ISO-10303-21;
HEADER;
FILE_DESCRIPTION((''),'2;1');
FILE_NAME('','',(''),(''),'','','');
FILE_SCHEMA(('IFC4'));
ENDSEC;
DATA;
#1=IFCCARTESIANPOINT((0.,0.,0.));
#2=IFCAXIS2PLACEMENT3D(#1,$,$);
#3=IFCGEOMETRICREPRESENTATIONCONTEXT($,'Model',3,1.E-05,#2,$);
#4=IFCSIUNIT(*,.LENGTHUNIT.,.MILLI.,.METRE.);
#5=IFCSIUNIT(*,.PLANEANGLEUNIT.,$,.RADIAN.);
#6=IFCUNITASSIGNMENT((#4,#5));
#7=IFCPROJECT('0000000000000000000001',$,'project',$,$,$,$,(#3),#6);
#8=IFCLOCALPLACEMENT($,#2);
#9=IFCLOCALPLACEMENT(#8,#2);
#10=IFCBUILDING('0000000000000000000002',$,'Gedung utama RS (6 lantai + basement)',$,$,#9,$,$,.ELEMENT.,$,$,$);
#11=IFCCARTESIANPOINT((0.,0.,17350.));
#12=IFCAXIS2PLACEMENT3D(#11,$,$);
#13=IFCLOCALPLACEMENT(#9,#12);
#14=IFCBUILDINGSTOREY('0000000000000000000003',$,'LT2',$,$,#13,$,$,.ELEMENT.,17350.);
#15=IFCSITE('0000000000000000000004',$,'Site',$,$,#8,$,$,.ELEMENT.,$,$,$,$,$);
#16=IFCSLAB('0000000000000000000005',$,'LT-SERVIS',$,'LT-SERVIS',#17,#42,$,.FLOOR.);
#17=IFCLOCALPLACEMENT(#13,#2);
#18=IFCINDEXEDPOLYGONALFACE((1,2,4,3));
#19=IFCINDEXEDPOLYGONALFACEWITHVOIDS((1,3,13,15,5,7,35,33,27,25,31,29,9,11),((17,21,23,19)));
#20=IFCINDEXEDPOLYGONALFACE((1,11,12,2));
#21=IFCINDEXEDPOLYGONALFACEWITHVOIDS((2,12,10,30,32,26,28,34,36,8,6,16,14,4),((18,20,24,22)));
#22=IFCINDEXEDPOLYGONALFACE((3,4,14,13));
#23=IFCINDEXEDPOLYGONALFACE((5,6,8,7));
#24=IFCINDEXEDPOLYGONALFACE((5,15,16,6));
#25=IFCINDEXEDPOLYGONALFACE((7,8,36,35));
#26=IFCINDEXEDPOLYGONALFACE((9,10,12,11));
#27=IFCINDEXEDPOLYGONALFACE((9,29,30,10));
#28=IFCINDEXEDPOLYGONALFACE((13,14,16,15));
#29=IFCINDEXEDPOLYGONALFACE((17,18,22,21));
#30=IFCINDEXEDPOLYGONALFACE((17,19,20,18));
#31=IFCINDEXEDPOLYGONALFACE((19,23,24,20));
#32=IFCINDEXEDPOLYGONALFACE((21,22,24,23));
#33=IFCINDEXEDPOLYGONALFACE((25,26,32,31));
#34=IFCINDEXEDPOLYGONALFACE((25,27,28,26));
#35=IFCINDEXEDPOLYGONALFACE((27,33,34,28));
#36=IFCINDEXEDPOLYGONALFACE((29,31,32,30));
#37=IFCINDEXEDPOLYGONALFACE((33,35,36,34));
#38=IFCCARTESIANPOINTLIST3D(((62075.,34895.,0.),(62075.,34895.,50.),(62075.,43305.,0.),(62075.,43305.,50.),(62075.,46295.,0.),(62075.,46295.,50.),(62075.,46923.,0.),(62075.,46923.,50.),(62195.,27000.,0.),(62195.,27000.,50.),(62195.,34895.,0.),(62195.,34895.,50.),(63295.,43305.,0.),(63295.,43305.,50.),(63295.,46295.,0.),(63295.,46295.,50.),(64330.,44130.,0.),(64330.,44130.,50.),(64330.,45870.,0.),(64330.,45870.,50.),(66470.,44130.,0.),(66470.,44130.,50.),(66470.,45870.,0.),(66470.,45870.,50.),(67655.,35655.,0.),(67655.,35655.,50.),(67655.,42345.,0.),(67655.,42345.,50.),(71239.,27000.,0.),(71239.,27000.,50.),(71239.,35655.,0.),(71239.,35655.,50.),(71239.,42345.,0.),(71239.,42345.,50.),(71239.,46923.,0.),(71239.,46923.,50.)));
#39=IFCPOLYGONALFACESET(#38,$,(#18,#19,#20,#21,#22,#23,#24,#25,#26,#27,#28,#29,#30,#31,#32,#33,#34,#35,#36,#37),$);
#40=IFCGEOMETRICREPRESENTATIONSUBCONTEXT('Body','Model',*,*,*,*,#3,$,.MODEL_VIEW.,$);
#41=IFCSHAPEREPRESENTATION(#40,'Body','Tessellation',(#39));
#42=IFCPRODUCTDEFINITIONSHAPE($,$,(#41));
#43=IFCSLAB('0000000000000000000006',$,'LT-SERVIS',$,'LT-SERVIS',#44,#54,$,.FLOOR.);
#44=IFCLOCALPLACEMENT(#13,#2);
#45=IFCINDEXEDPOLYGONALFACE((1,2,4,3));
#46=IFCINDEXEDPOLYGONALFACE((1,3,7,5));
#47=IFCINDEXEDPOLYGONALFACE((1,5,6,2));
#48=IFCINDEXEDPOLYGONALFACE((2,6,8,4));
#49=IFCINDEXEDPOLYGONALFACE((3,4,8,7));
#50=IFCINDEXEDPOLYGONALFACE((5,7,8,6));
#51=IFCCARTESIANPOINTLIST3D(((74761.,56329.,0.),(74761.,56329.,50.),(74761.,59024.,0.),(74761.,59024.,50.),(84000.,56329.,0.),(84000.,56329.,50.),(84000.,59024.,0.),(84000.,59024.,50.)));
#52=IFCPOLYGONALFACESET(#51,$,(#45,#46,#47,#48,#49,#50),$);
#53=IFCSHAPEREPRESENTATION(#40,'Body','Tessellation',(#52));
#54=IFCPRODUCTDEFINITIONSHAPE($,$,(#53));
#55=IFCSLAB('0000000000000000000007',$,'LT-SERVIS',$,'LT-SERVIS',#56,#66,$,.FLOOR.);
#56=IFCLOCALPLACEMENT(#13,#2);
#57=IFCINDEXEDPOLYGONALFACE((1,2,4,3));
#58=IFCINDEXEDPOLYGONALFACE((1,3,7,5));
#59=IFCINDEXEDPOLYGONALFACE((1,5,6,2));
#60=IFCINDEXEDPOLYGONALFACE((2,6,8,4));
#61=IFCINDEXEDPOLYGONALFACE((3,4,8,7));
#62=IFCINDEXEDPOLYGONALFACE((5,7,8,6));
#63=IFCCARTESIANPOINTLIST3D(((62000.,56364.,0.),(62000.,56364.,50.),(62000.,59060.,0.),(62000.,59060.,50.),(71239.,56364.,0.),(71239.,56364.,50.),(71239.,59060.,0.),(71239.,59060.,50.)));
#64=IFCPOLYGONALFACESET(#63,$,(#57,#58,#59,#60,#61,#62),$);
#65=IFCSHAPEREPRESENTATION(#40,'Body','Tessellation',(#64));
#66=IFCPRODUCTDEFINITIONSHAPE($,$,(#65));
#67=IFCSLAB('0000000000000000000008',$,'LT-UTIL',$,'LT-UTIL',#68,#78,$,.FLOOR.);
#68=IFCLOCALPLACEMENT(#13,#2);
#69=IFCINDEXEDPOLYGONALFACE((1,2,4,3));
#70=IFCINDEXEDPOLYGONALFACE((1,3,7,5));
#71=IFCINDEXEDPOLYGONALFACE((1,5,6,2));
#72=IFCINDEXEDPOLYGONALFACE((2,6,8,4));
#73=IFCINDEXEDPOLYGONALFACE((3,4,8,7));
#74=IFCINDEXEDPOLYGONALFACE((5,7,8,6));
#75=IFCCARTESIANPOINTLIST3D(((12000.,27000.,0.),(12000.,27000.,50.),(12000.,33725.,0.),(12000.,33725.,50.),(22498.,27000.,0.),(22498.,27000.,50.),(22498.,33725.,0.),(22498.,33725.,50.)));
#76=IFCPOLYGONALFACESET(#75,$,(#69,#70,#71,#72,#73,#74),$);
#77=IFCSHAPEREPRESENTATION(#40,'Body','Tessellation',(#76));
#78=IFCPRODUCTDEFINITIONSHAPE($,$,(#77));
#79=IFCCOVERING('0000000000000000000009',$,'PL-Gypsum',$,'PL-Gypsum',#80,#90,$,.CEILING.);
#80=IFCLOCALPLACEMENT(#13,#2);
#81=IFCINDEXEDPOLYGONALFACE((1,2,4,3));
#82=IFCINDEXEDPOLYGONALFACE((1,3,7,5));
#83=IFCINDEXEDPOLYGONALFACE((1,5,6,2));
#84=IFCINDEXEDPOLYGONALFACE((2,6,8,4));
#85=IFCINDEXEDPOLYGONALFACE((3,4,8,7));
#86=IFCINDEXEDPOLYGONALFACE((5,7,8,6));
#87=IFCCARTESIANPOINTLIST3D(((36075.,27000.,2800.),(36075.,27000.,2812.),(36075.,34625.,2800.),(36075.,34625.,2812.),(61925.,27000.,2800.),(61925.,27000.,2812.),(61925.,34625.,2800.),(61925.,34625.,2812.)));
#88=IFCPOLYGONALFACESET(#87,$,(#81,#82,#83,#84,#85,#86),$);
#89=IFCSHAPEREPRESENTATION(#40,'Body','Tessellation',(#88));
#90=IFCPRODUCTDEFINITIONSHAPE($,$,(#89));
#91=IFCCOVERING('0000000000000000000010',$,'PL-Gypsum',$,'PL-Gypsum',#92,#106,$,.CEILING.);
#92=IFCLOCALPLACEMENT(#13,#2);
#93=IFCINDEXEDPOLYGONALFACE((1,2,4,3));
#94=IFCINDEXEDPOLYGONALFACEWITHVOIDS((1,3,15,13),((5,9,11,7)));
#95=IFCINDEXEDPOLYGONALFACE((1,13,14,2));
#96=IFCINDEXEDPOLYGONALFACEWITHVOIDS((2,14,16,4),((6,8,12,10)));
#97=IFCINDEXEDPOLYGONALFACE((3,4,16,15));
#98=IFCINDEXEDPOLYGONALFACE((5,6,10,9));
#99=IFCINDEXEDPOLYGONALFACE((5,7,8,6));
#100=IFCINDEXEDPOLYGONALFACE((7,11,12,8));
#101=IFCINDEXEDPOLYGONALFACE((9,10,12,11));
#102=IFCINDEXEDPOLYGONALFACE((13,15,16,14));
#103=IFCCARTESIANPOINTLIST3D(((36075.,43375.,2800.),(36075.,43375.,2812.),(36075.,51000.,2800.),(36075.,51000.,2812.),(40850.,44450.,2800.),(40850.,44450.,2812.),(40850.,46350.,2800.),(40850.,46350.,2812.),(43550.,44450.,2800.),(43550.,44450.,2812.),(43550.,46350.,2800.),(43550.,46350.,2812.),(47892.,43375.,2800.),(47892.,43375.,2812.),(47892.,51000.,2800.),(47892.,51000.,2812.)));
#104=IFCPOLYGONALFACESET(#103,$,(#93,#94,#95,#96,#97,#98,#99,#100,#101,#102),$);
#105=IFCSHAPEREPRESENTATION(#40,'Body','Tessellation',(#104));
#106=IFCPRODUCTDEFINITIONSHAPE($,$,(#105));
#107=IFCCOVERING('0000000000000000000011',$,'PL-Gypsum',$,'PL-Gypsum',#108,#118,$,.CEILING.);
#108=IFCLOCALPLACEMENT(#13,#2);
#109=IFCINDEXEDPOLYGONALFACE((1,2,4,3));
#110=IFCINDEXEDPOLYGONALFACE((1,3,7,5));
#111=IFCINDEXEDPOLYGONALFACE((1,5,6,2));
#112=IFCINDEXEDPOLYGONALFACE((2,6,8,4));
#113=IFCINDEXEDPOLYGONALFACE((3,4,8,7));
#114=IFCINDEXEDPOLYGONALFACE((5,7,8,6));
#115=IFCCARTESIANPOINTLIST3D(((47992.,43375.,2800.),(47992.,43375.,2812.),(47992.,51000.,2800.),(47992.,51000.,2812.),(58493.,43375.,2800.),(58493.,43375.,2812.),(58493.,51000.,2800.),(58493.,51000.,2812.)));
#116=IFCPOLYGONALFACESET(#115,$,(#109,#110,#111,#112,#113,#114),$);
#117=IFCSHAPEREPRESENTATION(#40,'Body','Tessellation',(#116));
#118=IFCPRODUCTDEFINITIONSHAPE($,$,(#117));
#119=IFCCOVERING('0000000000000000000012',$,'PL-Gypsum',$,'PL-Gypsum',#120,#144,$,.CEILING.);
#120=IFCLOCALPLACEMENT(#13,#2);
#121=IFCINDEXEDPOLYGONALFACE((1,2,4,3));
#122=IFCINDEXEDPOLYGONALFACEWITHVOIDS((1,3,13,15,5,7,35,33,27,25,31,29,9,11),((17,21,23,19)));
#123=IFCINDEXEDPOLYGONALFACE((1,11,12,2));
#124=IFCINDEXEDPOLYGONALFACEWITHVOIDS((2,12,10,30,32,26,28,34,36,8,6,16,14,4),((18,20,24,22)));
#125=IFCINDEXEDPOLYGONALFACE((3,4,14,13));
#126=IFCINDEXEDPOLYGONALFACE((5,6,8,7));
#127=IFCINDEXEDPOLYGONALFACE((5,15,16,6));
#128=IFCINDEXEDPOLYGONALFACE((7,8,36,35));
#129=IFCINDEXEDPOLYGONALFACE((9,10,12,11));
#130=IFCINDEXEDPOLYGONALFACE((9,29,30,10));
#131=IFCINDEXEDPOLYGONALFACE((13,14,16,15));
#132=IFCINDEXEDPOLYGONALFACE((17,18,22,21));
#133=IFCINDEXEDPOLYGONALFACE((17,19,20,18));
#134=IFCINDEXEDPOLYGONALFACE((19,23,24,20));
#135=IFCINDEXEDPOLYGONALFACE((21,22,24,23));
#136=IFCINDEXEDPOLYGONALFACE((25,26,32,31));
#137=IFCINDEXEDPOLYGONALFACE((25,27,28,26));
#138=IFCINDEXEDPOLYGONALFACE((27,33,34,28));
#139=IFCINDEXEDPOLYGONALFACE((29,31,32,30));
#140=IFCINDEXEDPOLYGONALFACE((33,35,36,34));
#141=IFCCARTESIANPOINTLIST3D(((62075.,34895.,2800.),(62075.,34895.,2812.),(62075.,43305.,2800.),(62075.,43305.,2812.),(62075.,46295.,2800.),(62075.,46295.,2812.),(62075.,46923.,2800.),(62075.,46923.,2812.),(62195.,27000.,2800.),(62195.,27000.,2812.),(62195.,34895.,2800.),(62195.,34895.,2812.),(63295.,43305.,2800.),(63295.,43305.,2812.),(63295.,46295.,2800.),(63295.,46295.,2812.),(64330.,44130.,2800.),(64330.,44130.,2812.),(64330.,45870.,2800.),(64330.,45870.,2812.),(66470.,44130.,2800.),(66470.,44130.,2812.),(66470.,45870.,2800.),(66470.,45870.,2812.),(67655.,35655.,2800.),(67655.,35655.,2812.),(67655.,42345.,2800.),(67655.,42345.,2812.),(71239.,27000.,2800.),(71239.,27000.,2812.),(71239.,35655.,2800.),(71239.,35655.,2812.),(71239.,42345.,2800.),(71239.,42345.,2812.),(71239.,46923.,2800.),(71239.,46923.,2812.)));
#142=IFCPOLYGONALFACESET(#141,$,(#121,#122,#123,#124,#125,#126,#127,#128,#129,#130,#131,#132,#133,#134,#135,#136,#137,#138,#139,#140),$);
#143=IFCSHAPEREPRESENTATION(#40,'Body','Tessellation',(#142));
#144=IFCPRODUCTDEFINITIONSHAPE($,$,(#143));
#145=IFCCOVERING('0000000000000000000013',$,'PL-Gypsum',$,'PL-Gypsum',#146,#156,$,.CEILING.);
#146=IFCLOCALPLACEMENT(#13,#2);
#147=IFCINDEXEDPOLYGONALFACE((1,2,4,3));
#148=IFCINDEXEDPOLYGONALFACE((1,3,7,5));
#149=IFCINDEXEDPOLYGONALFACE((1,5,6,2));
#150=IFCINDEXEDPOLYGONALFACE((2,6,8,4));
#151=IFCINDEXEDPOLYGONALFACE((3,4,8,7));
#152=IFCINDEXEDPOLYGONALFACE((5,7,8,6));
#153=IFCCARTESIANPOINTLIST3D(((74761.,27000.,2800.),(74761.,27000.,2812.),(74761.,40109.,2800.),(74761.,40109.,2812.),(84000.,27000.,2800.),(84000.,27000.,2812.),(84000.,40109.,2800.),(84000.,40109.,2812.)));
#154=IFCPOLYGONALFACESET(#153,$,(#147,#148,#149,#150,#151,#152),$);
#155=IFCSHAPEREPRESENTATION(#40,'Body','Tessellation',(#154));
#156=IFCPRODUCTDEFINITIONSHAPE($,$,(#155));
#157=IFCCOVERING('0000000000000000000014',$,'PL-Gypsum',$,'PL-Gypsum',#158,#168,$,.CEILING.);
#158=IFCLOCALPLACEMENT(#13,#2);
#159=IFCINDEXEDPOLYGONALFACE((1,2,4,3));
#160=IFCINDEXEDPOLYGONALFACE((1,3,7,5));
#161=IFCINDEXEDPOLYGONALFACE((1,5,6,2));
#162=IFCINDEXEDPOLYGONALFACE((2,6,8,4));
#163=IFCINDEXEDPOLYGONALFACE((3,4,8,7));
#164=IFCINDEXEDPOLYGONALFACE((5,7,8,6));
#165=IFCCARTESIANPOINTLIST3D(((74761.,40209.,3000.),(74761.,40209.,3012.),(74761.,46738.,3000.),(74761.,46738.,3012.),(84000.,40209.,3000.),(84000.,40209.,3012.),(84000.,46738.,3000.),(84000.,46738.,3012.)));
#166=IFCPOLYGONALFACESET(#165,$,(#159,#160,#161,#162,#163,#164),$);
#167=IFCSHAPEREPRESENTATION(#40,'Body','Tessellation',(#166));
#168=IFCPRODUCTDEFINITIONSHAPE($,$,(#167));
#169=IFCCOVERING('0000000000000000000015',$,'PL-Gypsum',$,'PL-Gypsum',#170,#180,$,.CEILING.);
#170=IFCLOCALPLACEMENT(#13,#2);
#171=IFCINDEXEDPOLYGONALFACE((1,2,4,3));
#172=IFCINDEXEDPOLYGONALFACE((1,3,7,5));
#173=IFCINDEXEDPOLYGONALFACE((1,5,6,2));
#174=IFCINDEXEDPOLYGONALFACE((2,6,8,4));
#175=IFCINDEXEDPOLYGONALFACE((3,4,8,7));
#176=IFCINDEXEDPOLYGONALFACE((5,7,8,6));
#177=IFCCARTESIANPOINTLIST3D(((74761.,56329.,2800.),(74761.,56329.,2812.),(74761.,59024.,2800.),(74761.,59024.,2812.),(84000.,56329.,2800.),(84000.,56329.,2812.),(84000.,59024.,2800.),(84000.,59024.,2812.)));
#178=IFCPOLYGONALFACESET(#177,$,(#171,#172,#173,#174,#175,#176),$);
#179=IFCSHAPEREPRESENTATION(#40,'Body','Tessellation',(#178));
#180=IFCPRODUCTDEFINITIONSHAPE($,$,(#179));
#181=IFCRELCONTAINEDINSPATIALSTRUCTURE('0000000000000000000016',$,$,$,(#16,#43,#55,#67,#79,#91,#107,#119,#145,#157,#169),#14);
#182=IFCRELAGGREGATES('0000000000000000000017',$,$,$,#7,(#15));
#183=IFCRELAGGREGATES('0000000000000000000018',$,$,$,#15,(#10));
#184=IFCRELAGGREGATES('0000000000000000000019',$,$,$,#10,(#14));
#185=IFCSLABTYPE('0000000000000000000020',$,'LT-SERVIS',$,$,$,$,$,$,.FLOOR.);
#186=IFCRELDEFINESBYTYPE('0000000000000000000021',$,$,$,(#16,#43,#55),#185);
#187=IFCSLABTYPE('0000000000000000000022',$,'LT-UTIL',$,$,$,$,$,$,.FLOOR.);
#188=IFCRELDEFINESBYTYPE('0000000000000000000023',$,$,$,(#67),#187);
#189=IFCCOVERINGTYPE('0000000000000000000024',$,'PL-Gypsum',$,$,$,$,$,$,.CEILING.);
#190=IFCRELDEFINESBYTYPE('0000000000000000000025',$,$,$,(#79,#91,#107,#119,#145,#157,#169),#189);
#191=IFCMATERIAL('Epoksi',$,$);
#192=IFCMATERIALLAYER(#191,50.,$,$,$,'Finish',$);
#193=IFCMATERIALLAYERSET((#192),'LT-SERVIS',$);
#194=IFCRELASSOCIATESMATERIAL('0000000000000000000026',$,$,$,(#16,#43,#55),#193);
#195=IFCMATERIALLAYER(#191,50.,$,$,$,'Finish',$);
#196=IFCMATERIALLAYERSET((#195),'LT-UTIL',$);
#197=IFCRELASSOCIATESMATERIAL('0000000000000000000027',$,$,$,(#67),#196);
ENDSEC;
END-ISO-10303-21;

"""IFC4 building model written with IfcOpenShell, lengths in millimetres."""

from ifc_helpers import new_model, si_unit, frame, origin, place, context, subcontext, project, spatial, polyline, outline, extrude, material, layer, layer_set, layer_usage, type_object, element, save


model = new_model("IFC4")

# Units and contexts
model_context = context("Model", 3, precision=1e-05, world=origin())
body_context = subcontext(model_context, "Body", "Model", "MODEL_VIEW")
ifc_project = project(units=[si_unit("LENGTHUNIT", "METRE", prefix="MILLI"), si_unit("PLANEANGLEUNIT", "RADIAN")], contexts=[model_context])

# Site, building, storey
site_placement = place(None, origin())
site = spatial("IfcSite", under=ifc_project, at=site_placement, Name="Site", CompositionType="ELEMENT")
building_placement = place(site_placement, origin())
building = spatial("IfcBuilding", under=site, at=building_placement, Name="Gedung utama RS (6 lantai + basement)", CompositionType="ELEMENT")
storey_placement = place(building_placement, frame((0.0, 0.0, 17350.0)))
storey = spatial("IfcBuildingStorey", under=building, at=storey_placement, Name="LT2", CompositionType="ELEMENT", Elevation=17350.0)

# Slabs
ifc_material_1 = material(Name="Epoksi")
ifc_layer_1 = layer(ifc_material_1, 50.0, Category="Finish")
ifc_layer_set_1 = layer_set([ifc_layer_1], Name="LT-SERVIS")
ifc_layer_usage_1 = layer_usage(ifc_layer_set_1, "AXIS3", "NEGATIVE", 50.0)
slab_type_1 = type_object("IfcSlabType", Name="LT-SERVIS", PredefinedType="FLOOR")
slab_1_placement = place(storey_placement, origin())
element("IfcSlab", 1, at=slab_1_placement, inside=storey, type_object=slab_type_1, material=ifc_layer_usage_1, Name="LT-SERVIS", ObjectType="LT-SERVIS", PredefinedType="FLOOR", context=body_context, shape_type="SweptSolid", body=[
    extrude(outline(polyline([(62195.0, 27000.0), (71239.0, 27000.0), (71239.0, 35655.0), (67655.0, 35655.0), (67655.0, 42345.0), (71239.0, 42345.0), (71239.0, 46923.0), (62075.0, 46923.0), (62075.0, 46295.0), (63295.0, 46295.0), (63295.0, 43305.0), (62075.0, 43305.0), (62075.0, 34895.0), (62195.0, 34895.0), (62195.0, 27000.0)]), holes=[polyline([(64330.0, 44130.0), (64330.0, 45870.0), (66470.0, 45870.0), (66470.0, 44130.0), (64330.0, 44130.0)])]), origin(), (0.0, 0.0, 1.0), 50.0),
])
slab_2_placement = place(storey_placement, origin())
element("IfcSlab", 2, at=slab_2_placement, inside=storey, type_object=slab_type_1, material=ifc_layer_usage_1, Name="LT-SERVIS", ObjectType="LT-SERVIS", PredefinedType="FLOOR", context=body_context, shape_type="SweptSolid", body=[
    extrude(outline(polyline([(74761.0, 56329.0), (84000.0, 56329.0), (84000.0, 59024.0), (74761.0, 59024.0), (74761.0, 56329.0)])), origin(), (0.0, 0.0, 1.0), 50.0),
])
slab_3_placement = place(storey_placement, origin())
element("IfcSlab", 3, at=slab_3_placement, inside=storey, type_object=slab_type_1, material=ifc_layer_usage_1, Name="LT-SERVIS", ObjectType="LT-SERVIS", PredefinedType="FLOOR", context=body_context, shape_type="SweptSolid", body=[
    extrude(outline(polyline([(62000.0, 56364.0), (71239.0, 56364.0), (71239.0, 59060.0), (62000.0, 59060.0), (62000.0, 56364.0)])), origin(), (0.0, 0.0, 1.0), 50.0),
])
ifc_layer_2 = layer(ifc_material_1, 50.0, Category="Finish")
ifc_layer_set_2 = layer_set([ifc_layer_2], Name="LT-UTIL")
ifc_layer_usage_2 = layer_usage(ifc_layer_set_2, "AXIS3", "NEGATIVE", 50.0)
slab_type_2 = type_object("IfcSlabType", Name="LT-UTIL", PredefinedType="FLOOR")
slab_4_placement = place(storey_placement, origin())
element("IfcSlab", 4, at=slab_4_placement, inside=storey, type_object=slab_type_2, material=ifc_layer_usage_2, Name="LT-UTIL", ObjectType="LT-UTIL", PredefinedType="FLOOR", context=body_context, shape_type="SweptSolid", body=[
    extrude(outline(polyline([(12000.0, 27000.0), (22498.0, 27000.0), (22498.0, 33725.0), (12000.0, 33725.0), (12000.0, 27000.0)])), origin(), (0.0, 0.0, 1.0), 50.0),
])

# Coverings
covering_type = type_object("IfcCoveringType", Name="PL-Gypsum", PredefinedType="CEILING")
covering_1_placement = place(storey_placement, origin())
element("IfcCovering", 5, at=covering_1_placement, inside=storey, type_object=covering_type, Name="PL-Gypsum", ObjectType="PL-Gypsum", PredefinedType="CEILING", context=body_context, shape_type="SweptSolid", body=[
    extrude(outline(polyline([(36075.0, 27000.0), (61925.0, 27000.0), (61925.0, 34625.0), (36075.0, 34625.0), (36075.0, 27000.0)])), frame((0.0, 0.0, 2800.0)), (0.0, 0.0, 1.0), 12.0),
])
covering_2_placement = place(storey_placement, origin())
element("IfcCovering", 6, at=covering_2_placement, inside=storey, type_object=covering_type, Name="PL-Gypsum", ObjectType="PL-Gypsum", PredefinedType="CEILING", context=body_context, shape_type="SweptSolid", body=[
    extrude(outline(polyline([(36075.0, 43375.0), (47892.0, 43375.0), (47892.0, 51000.0), (36075.0, 51000.0), (36075.0, 43375.0)]), holes=[polyline([(40850.0, 44450.0), (40850.0, 46350.0), (43550.0, 46350.0), (43550.0, 44450.0), (40850.0, 44450.0)])]), frame((0.0, 0.0, 2800.0)), (0.0, 0.0, 1.0), 12.0),
])
covering_3_placement = place(storey_placement, origin())
element("IfcCovering", 7, at=covering_3_placement, inside=storey, type_object=covering_type, Name="PL-Gypsum", ObjectType="PL-Gypsum", PredefinedType="CEILING", context=body_context, shape_type="SweptSolid", body=[
    extrude(outline(polyline([(47992.0, 43375.0), (58493.0, 43375.0), (58493.0, 51000.0), (47992.0, 51000.0), (47992.0, 43375.0)])), frame((0.0, 0.0, 2800.0)), (0.0, 0.0, 1.0), 12.0),
])
covering_4_placement = place(storey_placement, origin())
element("IfcCovering", 8, at=covering_4_placement, inside=storey, type_object=covering_type, Name="PL-Gypsum", ObjectType="PL-Gypsum", PredefinedType="CEILING", context=body_context, shape_type="SweptSolid", body=[
    extrude(outline(polyline([(62195.0, 27000.0), (71239.0, 27000.0), (71239.0, 35655.0), (67655.0, 35655.0), (67655.0, 42345.0), (71239.0, 42345.0), (71239.0, 46923.0), (62075.0, 46923.0), (62075.0, 46295.0), (63295.0, 46295.0), (63295.0, 43305.0), (62075.0, 43305.0), (62075.0, 34895.0), (62195.0, 34895.0), (62195.0, 27000.0)]), holes=[polyline([(64330.0, 44130.0), (64330.0, 45870.0), (66470.0, 45870.0), (66470.0, 44130.0), (64330.0, 44130.0)])]), frame((0.0, 0.0, 2800.0)), (0.0, 0.0, 1.0), 12.0),
])
covering_5_placement = place(storey_placement, origin())
element("IfcCovering", 9, at=covering_5_placement, inside=storey, type_object=covering_type, Name="PL-Gypsum", ObjectType="PL-Gypsum", PredefinedType="CEILING", context=body_context, shape_type="SweptSolid", body=[
    extrude(outline(polyline([(74761.0, 27000.0), (84000.0, 27000.0), (84000.0, 40109.0), (74761.0, 40109.0), (74761.0, 27000.0)])), frame((0.0, 0.0, 2800.0)), (0.0, 0.0, 1.0), 12.0),
])
covering_6_placement = place(storey_placement, origin())
element("IfcCovering", 10, at=covering_6_placement, inside=storey, type_object=covering_type, Name="PL-Gypsum", ObjectType="PL-Gypsum", PredefinedType="CEILING", context=body_context, shape_type="SweptSolid", body=[
    extrude(outline(polyline([(74761.0, 40209.0), (84000.0, 40209.0), (84000.0, 46738.0), (74761.0, 46738.0), (74761.0, 40209.0)])), frame((0.0, 0.0, 3000.0)), (0.0, 0.0, 1.0), 12.0),
])
covering_7_placement = place(storey_placement, origin())
element("IfcCovering", 11, at=covering_7_placement, inside=storey, type_object=covering_type, Name="PL-Gypsum", ObjectType="PL-Gypsum", PredefinedType="CEILING", context=body_context, shape_type="SweptSolid", body=[
    extrude(outline(polyline([(74761.0, 56329.0), (84000.0, 56329.0), (84000.0, 59024.0), (74761.0, 59024.0), (74761.0, 56329.0)])), frame((0.0, 0.0, 2800.0)), (0.0, 0.0, 1.0), 12.0),
])

save(model, "model.ifc")
